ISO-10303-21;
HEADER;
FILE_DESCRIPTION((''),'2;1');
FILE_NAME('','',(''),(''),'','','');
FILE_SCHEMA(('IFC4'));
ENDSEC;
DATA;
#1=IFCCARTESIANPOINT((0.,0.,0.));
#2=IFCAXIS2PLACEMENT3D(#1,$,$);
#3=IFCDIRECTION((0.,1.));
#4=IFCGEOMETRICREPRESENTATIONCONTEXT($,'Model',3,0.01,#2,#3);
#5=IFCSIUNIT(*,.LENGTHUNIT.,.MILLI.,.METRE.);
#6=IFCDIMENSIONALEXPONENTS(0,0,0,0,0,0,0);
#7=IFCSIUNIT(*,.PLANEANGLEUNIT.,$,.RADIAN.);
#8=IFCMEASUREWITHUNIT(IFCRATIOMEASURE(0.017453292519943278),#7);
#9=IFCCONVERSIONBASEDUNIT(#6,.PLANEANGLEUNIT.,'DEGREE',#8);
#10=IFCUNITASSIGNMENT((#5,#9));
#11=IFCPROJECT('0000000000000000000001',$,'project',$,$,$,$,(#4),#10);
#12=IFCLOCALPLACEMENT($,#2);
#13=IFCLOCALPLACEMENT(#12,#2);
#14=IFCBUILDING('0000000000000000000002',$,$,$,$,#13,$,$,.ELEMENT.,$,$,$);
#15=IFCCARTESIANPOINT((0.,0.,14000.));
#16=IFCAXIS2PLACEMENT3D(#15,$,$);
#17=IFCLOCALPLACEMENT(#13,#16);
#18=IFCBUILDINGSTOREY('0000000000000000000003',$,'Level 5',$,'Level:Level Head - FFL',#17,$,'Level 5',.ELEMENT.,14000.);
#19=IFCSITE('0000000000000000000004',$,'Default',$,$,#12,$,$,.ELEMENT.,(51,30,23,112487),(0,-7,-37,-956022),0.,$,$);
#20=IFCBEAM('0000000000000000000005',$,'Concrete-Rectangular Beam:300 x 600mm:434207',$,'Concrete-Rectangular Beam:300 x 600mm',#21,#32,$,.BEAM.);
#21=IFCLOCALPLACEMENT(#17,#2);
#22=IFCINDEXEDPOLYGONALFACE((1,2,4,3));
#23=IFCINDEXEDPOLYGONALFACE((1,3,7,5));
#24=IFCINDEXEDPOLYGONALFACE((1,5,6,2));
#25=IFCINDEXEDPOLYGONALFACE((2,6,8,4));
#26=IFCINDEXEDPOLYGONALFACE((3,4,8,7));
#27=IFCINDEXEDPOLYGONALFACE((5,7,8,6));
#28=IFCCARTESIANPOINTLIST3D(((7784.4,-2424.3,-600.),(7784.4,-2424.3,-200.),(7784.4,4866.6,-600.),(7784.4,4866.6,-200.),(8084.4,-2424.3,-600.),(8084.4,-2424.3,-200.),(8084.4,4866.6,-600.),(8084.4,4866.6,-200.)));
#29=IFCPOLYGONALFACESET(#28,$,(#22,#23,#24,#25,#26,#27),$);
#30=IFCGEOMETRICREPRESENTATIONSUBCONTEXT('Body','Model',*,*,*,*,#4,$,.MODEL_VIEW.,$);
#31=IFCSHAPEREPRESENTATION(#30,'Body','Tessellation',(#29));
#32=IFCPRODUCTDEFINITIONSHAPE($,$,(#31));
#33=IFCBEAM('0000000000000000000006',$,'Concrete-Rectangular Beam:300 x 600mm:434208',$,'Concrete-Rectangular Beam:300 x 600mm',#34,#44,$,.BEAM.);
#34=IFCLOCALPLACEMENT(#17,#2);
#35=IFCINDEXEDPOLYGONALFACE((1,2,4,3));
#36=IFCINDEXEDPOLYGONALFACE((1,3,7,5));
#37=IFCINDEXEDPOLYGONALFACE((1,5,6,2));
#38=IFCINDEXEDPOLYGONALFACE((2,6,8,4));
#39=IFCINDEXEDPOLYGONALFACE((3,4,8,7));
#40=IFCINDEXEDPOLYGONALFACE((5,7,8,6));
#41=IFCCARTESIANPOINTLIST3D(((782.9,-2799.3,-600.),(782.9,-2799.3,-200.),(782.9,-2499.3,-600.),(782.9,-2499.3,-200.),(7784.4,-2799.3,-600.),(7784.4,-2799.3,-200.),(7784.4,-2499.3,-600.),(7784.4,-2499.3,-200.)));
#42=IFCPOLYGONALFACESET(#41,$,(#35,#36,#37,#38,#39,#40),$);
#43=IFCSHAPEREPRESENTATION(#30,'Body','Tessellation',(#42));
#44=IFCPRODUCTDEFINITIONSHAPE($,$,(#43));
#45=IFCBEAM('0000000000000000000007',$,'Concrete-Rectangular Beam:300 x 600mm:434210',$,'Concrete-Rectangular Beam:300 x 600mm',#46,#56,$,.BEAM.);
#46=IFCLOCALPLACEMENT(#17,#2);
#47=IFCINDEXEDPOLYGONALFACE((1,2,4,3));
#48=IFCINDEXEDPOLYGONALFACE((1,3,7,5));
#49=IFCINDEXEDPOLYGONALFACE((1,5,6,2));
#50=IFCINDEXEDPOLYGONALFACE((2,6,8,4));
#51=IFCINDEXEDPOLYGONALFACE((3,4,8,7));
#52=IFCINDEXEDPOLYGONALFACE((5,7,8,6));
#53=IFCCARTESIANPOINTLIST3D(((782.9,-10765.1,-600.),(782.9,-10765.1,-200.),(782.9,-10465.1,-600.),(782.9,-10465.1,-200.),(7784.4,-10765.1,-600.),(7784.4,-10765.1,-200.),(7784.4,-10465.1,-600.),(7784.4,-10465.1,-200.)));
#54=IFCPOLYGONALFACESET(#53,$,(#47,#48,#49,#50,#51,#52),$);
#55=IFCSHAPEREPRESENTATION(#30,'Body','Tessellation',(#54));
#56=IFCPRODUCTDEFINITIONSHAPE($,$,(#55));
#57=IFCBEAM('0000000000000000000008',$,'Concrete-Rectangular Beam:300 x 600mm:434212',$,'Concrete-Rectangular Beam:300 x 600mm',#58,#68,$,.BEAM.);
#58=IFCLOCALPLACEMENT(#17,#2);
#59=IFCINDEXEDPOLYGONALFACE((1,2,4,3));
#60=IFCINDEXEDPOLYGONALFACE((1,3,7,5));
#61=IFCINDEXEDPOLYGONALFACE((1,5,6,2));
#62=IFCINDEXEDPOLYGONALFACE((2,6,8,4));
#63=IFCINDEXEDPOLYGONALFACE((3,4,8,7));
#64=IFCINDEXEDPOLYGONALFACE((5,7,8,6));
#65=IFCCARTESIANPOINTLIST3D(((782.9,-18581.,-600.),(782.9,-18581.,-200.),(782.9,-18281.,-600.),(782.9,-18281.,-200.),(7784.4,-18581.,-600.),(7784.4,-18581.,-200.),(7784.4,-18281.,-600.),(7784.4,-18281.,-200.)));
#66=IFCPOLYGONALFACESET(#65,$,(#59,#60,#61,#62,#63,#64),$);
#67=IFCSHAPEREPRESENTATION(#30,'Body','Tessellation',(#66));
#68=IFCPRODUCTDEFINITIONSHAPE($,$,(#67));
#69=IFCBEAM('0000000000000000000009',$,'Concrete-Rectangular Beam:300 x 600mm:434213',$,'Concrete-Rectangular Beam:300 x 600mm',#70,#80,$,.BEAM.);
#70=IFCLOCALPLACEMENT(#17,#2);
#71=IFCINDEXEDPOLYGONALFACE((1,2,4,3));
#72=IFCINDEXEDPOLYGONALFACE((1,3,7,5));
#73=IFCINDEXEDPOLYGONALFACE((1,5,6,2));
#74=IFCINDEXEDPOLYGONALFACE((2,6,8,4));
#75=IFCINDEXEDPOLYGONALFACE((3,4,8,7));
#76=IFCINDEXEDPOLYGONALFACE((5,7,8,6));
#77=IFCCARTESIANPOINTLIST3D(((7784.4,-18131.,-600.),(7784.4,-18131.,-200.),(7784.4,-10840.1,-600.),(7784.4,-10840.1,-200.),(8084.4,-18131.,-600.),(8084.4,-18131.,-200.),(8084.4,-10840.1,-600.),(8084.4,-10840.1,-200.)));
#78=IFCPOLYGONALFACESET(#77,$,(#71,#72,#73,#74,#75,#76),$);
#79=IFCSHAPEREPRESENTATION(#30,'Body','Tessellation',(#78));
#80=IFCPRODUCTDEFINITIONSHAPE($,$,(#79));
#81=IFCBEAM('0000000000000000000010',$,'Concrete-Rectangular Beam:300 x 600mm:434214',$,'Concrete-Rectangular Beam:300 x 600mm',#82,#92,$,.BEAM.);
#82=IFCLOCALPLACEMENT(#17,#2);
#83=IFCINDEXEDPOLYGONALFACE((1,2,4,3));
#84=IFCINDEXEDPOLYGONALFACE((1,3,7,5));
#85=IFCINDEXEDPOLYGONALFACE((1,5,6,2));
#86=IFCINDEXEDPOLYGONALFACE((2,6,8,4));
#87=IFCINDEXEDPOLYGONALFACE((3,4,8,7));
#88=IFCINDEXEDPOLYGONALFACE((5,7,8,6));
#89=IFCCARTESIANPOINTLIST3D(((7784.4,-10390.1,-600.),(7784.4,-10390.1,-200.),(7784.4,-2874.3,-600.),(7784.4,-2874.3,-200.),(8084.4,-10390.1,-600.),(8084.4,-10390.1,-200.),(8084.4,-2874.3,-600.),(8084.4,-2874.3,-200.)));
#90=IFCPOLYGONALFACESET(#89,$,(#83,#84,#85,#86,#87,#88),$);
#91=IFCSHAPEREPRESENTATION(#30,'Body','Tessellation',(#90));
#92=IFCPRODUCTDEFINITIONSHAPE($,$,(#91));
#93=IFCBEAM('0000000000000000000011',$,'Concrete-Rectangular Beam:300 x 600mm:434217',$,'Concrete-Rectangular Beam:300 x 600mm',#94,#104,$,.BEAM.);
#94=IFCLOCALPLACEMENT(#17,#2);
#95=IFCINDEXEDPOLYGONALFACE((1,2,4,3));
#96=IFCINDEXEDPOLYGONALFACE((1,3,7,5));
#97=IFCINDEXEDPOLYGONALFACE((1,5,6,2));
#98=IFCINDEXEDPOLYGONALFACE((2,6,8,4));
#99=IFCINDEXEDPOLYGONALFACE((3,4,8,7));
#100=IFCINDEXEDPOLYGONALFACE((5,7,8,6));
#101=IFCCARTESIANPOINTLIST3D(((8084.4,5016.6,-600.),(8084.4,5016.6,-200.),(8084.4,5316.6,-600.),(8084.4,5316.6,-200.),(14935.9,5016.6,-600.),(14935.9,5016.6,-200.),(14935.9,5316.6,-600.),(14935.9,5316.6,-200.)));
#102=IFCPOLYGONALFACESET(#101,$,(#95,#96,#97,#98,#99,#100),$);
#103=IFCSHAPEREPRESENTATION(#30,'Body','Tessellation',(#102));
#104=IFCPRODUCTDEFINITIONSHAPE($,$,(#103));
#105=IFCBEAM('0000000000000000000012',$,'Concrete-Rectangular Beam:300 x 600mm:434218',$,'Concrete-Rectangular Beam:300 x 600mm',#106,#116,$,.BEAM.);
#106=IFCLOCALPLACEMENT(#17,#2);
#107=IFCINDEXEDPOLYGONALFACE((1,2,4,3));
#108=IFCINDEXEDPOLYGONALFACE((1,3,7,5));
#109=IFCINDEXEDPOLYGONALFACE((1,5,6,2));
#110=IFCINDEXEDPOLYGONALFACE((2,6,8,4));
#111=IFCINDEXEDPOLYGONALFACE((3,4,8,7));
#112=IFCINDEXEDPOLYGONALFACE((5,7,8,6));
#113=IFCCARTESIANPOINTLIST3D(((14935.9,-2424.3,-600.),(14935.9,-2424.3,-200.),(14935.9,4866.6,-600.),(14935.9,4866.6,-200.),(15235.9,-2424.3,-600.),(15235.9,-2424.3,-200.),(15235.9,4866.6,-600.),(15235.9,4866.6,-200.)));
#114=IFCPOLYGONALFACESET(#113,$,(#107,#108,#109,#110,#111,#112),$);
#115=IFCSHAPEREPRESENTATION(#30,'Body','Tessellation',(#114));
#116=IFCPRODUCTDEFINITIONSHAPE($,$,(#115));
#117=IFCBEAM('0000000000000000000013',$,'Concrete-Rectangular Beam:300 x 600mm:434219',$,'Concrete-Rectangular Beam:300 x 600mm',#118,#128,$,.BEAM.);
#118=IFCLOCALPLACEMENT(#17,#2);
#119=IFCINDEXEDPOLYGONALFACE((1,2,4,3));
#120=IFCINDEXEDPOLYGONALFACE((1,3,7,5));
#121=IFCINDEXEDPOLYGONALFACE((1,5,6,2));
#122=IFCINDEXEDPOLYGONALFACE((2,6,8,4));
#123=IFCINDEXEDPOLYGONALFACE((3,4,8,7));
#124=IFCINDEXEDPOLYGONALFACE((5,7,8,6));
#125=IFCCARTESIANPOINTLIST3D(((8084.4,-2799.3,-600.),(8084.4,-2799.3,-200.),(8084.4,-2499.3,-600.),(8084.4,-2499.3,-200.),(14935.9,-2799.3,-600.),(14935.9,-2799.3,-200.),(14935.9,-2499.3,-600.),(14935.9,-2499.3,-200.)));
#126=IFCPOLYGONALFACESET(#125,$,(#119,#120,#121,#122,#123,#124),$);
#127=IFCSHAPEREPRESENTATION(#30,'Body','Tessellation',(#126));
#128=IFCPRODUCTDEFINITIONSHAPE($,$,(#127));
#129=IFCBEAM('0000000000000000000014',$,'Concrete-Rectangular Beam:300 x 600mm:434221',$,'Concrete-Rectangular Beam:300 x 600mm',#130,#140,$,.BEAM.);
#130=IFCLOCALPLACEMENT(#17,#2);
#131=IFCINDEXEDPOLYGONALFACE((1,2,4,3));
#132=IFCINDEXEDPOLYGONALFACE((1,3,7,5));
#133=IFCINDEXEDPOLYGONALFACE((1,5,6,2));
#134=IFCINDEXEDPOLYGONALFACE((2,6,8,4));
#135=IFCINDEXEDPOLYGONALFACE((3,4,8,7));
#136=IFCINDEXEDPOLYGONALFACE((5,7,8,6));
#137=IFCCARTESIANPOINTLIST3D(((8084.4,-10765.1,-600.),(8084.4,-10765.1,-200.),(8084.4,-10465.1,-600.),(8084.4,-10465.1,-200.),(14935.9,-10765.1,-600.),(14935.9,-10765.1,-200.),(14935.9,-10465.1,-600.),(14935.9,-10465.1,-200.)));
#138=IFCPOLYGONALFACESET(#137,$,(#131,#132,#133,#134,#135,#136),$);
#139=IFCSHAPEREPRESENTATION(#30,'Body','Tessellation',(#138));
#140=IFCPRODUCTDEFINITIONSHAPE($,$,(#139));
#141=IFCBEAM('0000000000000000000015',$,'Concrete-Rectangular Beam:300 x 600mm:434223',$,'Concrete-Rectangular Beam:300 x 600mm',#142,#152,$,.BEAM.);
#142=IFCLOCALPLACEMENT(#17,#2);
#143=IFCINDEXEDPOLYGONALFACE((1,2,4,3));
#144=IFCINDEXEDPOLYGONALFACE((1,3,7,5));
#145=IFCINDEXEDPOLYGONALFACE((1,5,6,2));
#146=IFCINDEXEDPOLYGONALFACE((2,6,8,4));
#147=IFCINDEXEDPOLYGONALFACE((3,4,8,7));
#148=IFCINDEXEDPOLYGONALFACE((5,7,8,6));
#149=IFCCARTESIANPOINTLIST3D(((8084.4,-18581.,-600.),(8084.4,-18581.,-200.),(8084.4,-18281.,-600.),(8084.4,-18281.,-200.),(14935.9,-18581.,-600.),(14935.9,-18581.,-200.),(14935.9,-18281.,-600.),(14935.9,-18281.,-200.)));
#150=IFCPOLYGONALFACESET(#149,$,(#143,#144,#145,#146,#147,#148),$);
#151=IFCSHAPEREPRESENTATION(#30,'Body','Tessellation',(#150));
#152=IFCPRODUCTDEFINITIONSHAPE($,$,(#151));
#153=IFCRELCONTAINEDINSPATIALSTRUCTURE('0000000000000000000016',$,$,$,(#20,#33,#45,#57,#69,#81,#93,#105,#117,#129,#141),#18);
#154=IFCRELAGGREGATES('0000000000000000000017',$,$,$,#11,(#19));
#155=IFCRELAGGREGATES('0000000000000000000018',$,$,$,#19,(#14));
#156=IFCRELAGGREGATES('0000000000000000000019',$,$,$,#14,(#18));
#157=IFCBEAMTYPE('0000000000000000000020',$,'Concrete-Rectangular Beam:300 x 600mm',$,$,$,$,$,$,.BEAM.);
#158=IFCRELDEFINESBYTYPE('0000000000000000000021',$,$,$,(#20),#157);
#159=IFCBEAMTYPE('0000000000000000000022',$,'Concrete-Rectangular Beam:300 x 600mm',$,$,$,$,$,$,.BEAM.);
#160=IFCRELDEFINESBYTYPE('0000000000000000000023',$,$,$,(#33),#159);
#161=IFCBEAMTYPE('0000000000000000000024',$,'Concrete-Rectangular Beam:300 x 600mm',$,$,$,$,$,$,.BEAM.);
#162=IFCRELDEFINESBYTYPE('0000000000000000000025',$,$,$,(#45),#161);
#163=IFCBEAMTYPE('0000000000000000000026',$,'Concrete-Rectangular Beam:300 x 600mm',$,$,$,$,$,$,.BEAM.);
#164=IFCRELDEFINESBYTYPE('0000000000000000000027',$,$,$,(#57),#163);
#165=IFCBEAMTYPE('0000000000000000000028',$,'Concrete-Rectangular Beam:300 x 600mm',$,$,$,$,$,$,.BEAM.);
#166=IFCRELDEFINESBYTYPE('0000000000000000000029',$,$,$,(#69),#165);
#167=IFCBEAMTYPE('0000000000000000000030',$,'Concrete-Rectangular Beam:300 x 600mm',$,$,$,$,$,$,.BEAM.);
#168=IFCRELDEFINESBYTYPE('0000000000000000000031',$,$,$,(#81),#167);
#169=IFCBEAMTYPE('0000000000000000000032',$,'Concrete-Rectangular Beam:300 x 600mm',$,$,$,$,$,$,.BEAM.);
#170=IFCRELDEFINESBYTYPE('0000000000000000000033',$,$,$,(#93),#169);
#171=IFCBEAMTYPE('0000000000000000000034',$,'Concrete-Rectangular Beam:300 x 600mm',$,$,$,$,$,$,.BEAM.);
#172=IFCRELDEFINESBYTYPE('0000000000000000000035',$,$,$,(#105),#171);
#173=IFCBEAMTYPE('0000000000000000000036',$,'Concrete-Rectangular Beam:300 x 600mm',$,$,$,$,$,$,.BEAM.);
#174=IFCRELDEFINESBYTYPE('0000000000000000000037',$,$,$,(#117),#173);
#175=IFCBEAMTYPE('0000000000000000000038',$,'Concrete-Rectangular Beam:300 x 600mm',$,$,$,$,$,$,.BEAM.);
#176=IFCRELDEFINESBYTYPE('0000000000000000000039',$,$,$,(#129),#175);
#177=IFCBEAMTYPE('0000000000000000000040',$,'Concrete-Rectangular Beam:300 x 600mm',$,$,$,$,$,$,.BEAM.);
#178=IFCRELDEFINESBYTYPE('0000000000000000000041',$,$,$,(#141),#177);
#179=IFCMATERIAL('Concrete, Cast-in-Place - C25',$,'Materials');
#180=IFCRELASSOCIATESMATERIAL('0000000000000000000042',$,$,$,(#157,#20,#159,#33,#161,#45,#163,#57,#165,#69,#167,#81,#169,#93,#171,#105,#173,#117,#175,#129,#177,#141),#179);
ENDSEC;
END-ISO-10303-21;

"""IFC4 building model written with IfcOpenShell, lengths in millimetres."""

from ifc_helpers import new_model, entity, si_unit, converted_unit, direction, frame, origin, place, context, subcontext, project, spatial, indexed_curve, outline, extrude, source, transform, mapped, material, type_object, type_shapes, element, save


model = new_model("IFC4")

# Units and contexts
model_context = context("Model", 3, precision=0.01, world=origin(), true_north=direction((0.0, 1.0)))
body_context = subcontext(model_context, "Body", "Model", "MODEL_VIEW")
ifc_project = project(units=[si_unit("LENGTHUNIT", "METRE", prefix="MILLI"), converted_unit("PLANEANGLEUNIT", "DEGREE", entity("IfcRatioMeasure", 0.017453292519943278), si_unit("PLANEANGLEUNIT", "RADIAN"), dimensions=[0, 0, 0, 0, 0, 0, 0])], contexts=[model_context])

# Site, building, storey
site_placement = place(None, origin())
site = spatial("IfcSite", under=ifc_project, at=site_placement, Name="Default", CompositionType="ELEMENT", RefLatitude=(51, 30, 23, 112487), RefLongitude=(0, -7, -37, -956022), RefElevation=0.0)
building_placement = place(site_placement, origin())
building = spatial("IfcBuilding", under=site, at=building_placement, CompositionType="ELEMENT")
storey_placement = place(building_placement, frame((0.0, 0.0, 14000.0)))
storey = spatial("IfcBuildingStorey", under=building, at=storey_placement, Name="Level 5", ObjectType="Level:Level Head - FFL", LongName="Level 5", CompositionType="ELEMENT", Elevation=14000.0)

# Beams
ifc_material = material(Name="Concrete, Cast-in-Place - C25", Category="Materials")
beam_type_1 = type_object("IfcBeamType", Name="Concrete-Rectangular Beam:300 x 600mm", PredefinedType="BEAM", material=ifc_material)
shared_shape_1 = source(origin(), body_context, "Body", "SweptSolid", [
    extrude(outline(indexed_curve([(-150.0, -200.0), (150.0, -200.0), (150.0, 200.0), (-150.0, 200.0), (-150.0, -200.0)], self_intersect=False)), frame((7934.4, 4866.6, 13600.0), z_axis=(0.0, -1.0, 0.0), x_axis=(-1.0, 0.0, 0.0)), (0.0, 0.0, 1.0), 7290.9),
])
type_shapes(beam_type_1, [shared_shape_1])
beam_1_placement = place(storey_placement, frame((0.0, 0.0, -14000.0)))
element("IfcBeam", 1, at=beam_1_placement, inside=storey, type_object=beam_type_1, material=ifc_material, Name="Concrete-Rectangular Beam:300 x 600mm:434207", ObjectType="Concrete-Rectangular Beam:300 x 600mm", PredefinedType="BEAM", context=body_context, shape_type="MappedRepresentation", body=[
    mapped(shared_shape_1, transform((0.0, 0.0, 0.0), scale=1.0)),
])
beam_type_2 = type_object("IfcBeamType", Name="Concrete-Rectangular Beam:300 x 600mm", PredefinedType="BEAM", material=ifc_material)
shared_shape_2 = source(origin(), body_context, "Body", "SweptSolid", [
    extrude(outline(indexed_curve([(-200.0, -150.0), (200.0, -150.0), (200.0, 150.0), (-200.0, 150.0), (-200.0, -150.0)], self_intersect=False)), frame((7784.4, -2649.3, 13600.0), z_axis=(-1.0, 0.0, 0.0), x_axis=(0.0, 0.0, -1.0)), (0.0, 0.0, 1.0), 7001.5),
])
type_shapes(beam_type_2, [shared_shape_2])
beam_2_placement = place(storey_placement, frame((0.0, 0.0, -14000.0)))
element("IfcBeam", 2, at=beam_2_placement, inside=storey, type_object=beam_type_2, material=ifc_material, Name="Concrete-Rectangular Beam:300 x 600mm:434208", ObjectType="Concrete-Rectangular Beam:300 x 600mm", PredefinedType="BEAM", context=body_context, shape_type="MappedRepresentation", body=[
    mapped(shared_shape_2, transform((0.0, 0.0, 0.0), scale=1.0)),
])
beam_type_3 = type_object("IfcBeamType", Name="Concrete-Rectangular Beam:300 x 600mm", PredefinedType="BEAM", material=ifc_material)
shared_shape_3 = source(origin(), body_context, "Body", "SweptSolid", [
    extrude(outline(indexed_curve([(-200.0, -150.0), (200.0, -150.0), (200.0, 150.0), (-200.0, 150.0), (-200.0, -150.0)], self_intersect=False)), frame((7784.4, -10615.1, 13600.0), z_axis=(-1.0, 0.0, 0.0), x_axis=(0.0, 0.0, -1.0)), (0.0, 0.0, 1.0), 7001.5),
])
type_shapes(beam_type_3, [shared_shape_3])
beam_3_placement = place(storey_placement, frame((0.0, 0.0, -14000.0)))
element("IfcBeam", 3, at=beam_3_placement, inside=storey, type_object=beam_type_3, material=ifc_material, Name="Concrete-Rectangular Beam:300 x 600mm:434210", ObjectType="Concrete-Rectangular Beam:300 x 600mm", PredefinedType="BEAM", context=body_context, shape_type="MappedRepresentation", body=[
    mapped(shared_shape_3, transform((0.0, 0.0, 0.0), scale=1.0)),
])
beam_type_4 = type_object("IfcBeamType", Name="Concrete-Rectangular Beam:300 x 600mm", PredefinedType="BEAM", material=ifc_material)
shared_shape_4 = source(origin(), body_context, "Body", "SweptSolid", [
    extrude(outline(indexed_curve([(-200.0, -150.0), (200.0, -150.0), (200.0, 150.0), (-200.0, 150.0), (-200.0, -150.0)], self_intersect=False)), frame((7784.4, -18431.0, 13600.0), z_axis=(-1.0, 0.0, 0.0), x_axis=(0.0, 0.0, -1.0)), (0.0, 0.0, 1.0), 7001.5),
])
type_shapes(beam_type_4, [shared_shape_4])
beam_4_placement = place(storey_placement, frame((0.0, 0.0, -14000.0)))
element("IfcBeam", 4, at=beam_4_placement, inside=storey, type_object=beam_type_4, material=ifc_material, Name="Concrete-Rectangular Beam:300 x 600mm:434212", ObjectType="Concrete-Rectangular Beam:300 x 600mm", PredefinedType="BEAM", context=body_context, shape_type="MappedRepresentation", body=[
    mapped(shared_shape_4, transform((0.0, 0.0, 0.0), scale=1.0)),
])
beam_type_5 = type_object("IfcBeamType", Name="Concrete-Rectangular Beam:300 x 600mm", PredefinedType="BEAM", material=ifc_material)
shared_shape_5 = source(origin(), body_context, "Body", "SweptSolid", [
    extrude(outline(indexed_curve([(-150.0, -200.0), (150.0, -200.0), (150.0, 200.0), (-150.0, 200.0), (-150.0, -200.0)], self_intersect=False)), frame((7934.4, -18131.0, 13600.0), z_axis=(0.0, 1.0, 0.0), x_axis=(-1.0, 0.0, 0.0)), (0.0, 0.0, 1.0), 7290.9),
])
type_shapes(beam_type_5, [shared_shape_5])
beam_5_placement = place(storey_placement, frame((0.0, 0.0, -14000.0)))
element("IfcBeam", 5, at=beam_5_placement, inside=storey, type_object=beam_type_5, material=ifc_material, Name="Concrete-Rectangular Beam:300 x 600mm:434213", ObjectType="Concrete-Rectangular Beam:300 x 600mm", PredefinedType="BEAM", context=body_context, shape_type="MappedRepresentation", body=[
    mapped(shared_shape_5, transform((0.0, 0.0, 0.0), scale=1.0)),
])
beam_type_6 = type_object("IfcBeamType", Name="Concrete-Rectangular Beam:300 x 600mm", PredefinedType="BEAM", material=ifc_material)
shared_shape_6 = source(origin(), body_context, "Body", "SweptSolid", [
    extrude(outline(indexed_curve([(-150.0, -200.0), (150.0, -200.0), (150.0, 200.0), (-150.0, 200.0), (-150.0, -200.0)], self_intersect=False)), frame((7934.4, -10390.1, 13600.0), z_axis=(0.0, 1.0, 0.0), x_axis=(-1.0, 0.0, 0.0)), (0.0, 0.0, 1.0), 7515.9),
])
type_shapes(beam_type_6, [shared_shape_6])
beam_6_placement = place(storey_placement, frame((0.0, 0.0, -14000.0)))
element("IfcBeam", 6, at=beam_6_placement, inside=storey, type_object=beam_type_6, material=ifc_material, Name="Concrete-Rectangular Beam:300 x 600mm:434214", ObjectType="Concrete-Rectangular Beam:300 x 600mm", PredefinedType="BEAM", context=body_context, shape_type="MappedRepresentation", body=[
    mapped(shared_shape_6, transform((0.0, 0.0, 0.0), scale=1.0)),
])
beam_type_7 = type_object("IfcBeamType", Name="Concrete-Rectangular Beam:300 x 600mm", PredefinedType="BEAM", material=ifc_material)
shared_shape_7 = source(origin(), body_context, "Body", "SweptSolid", [
    extrude(outline(indexed_curve([(-200.0, -150.0), (200.0, -150.0), (200.0, 150.0), (-200.0, 150.0), (-200.0, -150.0)], self_intersect=False)), frame((8084.4, 5166.6, 13600.0), z_axis=(1.0, 0.0, 0.0), x_axis=(0.0, 0.0, -1.0)), (0.0, 0.0, 1.0), 6851.5),
])
type_shapes(beam_type_7, [shared_shape_7])
beam_7_placement = place(storey_placement, frame((0.0, 0.0, -14000.0)))
element("IfcBeam", 7, at=beam_7_placement, inside=storey, type_object=beam_type_7, material=ifc_material, Name="Concrete-Rectangular Beam:300 x 600mm:434217", ObjectType="Concrete-Rectangular Beam:300 x 600mm", PredefinedType="BEAM", context=body_context, shape_type="MappedRepresentation", body=[
    mapped(shared_shape_7, transform((0.0, 0.0, 0.0), scale=1.0)),
])
beam_type_8 = type_object("IfcBeamType", Name="Concrete-Rectangular Beam:300 x 600mm", PredefinedType="BEAM", material=ifc_material)
shared_shape_8 = source(origin(), body_context, "Body", "SweptSolid", [
    extrude(outline(indexed_curve([(-150.0, -200.0), (150.0, -200.0), (150.0, 200.0), (-150.0, 200.0), (-150.0, -200.0)], self_intersect=False)), frame((15085.9, 4866.6, 13600.0), z_axis=(0.0, -1.0, 0.0), x_axis=(-1.0, 0.0, 0.0)), (0.0, 0.0, 1.0), 7290.9),
])
type_shapes(beam_type_8, [shared_shape_8])
beam_8_placement = place(storey_placement, frame((0.0, 0.0, -14000.0)))
element("IfcBeam", 8, at=beam_8_placement, inside=storey, type_object=beam_type_8, material=ifc_material, Name="Concrete-Rectangular Beam:300 x 600mm:434218", ObjectType="Concrete-Rectangular Beam:300 x 600mm", PredefinedType="BEAM", context=body_context, shape_type="MappedRepresentation", body=[
    mapped(shared_shape_8, transform((0.0, 0.0, 0.0), scale=1.0)),
])
beam_type_9 = type_object("IfcBeamType", Name="Concrete-Rectangular Beam:300 x 600mm", PredefinedType="BEAM", material=ifc_material)
shared_shape_9 = source(origin(), body_context, "Body", "SweptSolid", [
    extrude(outline(indexed_curve([(-200.0, -150.0), (200.0, -150.0), (200.0, 150.0), (-200.0, 150.0), (-200.0, -150.0)], self_intersect=False)), frame((14935.9, -2649.3, 13600.0), z_axis=(-1.0, 0.0, 0.0), x_axis=(0.0, 0.0, -1.0)), (0.0, 0.0, 1.0), 6851.5),
])
type_shapes(beam_type_9, [shared_shape_9])
beam_9_placement = place(storey_placement, frame((0.0, 0.0, -14000.0)))
element("IfcBeam", 9, at=beam_9_placement, inside=storey, type_object=beam_type_9, material=ifc_material, Name="Concrete-Rectangular Beam:300 x 600mm:434219", ObjectType="Concrete-Rectangular Beam:300 x 600mm", PredefinedType="BEAM", context=body_context, shape_type="MappedRepresentation", body=[
    mapped(shared_shape_9, transform((0.0, 0.0, 0.0), scale=1.0)),
])
beam_type_10 = type_object("IfcBeamType", Name="Concrete-Rectangular Beam:300 x 600mm", PredefinedType="BEAM", material=ifc_material)
shared_shape_10 = source(origin(), body_context, "Body", "SweptSolid", [
    extrude(outline(indexed_curve([(-200.0, -150.0), (200.0, -150.0), (200.0, 150.0), (-200.0, 150.0), (-200.0, -150.0)], self_intersect=False)), frame((14935.9, -10615.1, 13600.0), z_axis=(-1.0, 0.0, 0.0), x_axis=(0.0, 0.0, -1.0)), (0.0, 0.0, 1.0), 6851.5),
])
type_shapes(beam_type_10, [shared_shape_10])
beam_10_placement = place(storey_placement, frame((0.0, 0.0, -14000.0)))
element("IfcBeam", 10, at=beam_10_placement, inside=storey, type_object=beam_type_10, material=ifc_material, Name="Concrete-Rectangular Beam:300 x 600mm:434221", ObjectType="Concrete-Rectangular Beam:300 x 600mm", PredefinedType="BEAM", context=body_context, shape_type="MappedRepresentation", body=[
    mapped(shared_shape_10, transform((0.0, 0.0, 0.0), scale=1.0)),
])
beam_type_11 = type_object("IfcBeamType", Name="Concrete-Rectangular Beam:300 x 600mm", PredefinedType="BEAM", material=ifc_material)
shared_shape_11 = source(origin(), body_context, "Body", "SweptSolid", [
    extrude(outline(indexed_curve([(-200.0, -150.0), (200.0, -150.0), (200.0, 150.0), (-200.0, 150.0), (-200.0, -150.0)], self_intersect=False)), frame((14935.9, -18431.0, 13600.0), z_axis=(-1.0, 0.0, 0.0), x_axis=(0.0, 0.0, -1.0)), (0.0, 0.0, 1.0), 6851.5),
])
type_shapes(beam_type_11, [shared_shape_11])
beam_11_placement = place(storey_placement, frame((0.0, 0.0, -14000.0)))
element("IfcBeam", 11, at=beam_11_placement, inside=storey, type_object=beam_type_11, material=ifc_material, Name="Concrete-Rectangular Beam:300 x 600mm:434223", ObjectType="Concrete-Rectangular Beam:300 x 600mm", PredefinedType="BEAM", context=body_context, shape_type="MappedRepresentation", body=[
    mapped(shared_shape_11, transform((0.0, 0.0, 0.0), scale=1.0)),
])

save(model, "model.ifc")
